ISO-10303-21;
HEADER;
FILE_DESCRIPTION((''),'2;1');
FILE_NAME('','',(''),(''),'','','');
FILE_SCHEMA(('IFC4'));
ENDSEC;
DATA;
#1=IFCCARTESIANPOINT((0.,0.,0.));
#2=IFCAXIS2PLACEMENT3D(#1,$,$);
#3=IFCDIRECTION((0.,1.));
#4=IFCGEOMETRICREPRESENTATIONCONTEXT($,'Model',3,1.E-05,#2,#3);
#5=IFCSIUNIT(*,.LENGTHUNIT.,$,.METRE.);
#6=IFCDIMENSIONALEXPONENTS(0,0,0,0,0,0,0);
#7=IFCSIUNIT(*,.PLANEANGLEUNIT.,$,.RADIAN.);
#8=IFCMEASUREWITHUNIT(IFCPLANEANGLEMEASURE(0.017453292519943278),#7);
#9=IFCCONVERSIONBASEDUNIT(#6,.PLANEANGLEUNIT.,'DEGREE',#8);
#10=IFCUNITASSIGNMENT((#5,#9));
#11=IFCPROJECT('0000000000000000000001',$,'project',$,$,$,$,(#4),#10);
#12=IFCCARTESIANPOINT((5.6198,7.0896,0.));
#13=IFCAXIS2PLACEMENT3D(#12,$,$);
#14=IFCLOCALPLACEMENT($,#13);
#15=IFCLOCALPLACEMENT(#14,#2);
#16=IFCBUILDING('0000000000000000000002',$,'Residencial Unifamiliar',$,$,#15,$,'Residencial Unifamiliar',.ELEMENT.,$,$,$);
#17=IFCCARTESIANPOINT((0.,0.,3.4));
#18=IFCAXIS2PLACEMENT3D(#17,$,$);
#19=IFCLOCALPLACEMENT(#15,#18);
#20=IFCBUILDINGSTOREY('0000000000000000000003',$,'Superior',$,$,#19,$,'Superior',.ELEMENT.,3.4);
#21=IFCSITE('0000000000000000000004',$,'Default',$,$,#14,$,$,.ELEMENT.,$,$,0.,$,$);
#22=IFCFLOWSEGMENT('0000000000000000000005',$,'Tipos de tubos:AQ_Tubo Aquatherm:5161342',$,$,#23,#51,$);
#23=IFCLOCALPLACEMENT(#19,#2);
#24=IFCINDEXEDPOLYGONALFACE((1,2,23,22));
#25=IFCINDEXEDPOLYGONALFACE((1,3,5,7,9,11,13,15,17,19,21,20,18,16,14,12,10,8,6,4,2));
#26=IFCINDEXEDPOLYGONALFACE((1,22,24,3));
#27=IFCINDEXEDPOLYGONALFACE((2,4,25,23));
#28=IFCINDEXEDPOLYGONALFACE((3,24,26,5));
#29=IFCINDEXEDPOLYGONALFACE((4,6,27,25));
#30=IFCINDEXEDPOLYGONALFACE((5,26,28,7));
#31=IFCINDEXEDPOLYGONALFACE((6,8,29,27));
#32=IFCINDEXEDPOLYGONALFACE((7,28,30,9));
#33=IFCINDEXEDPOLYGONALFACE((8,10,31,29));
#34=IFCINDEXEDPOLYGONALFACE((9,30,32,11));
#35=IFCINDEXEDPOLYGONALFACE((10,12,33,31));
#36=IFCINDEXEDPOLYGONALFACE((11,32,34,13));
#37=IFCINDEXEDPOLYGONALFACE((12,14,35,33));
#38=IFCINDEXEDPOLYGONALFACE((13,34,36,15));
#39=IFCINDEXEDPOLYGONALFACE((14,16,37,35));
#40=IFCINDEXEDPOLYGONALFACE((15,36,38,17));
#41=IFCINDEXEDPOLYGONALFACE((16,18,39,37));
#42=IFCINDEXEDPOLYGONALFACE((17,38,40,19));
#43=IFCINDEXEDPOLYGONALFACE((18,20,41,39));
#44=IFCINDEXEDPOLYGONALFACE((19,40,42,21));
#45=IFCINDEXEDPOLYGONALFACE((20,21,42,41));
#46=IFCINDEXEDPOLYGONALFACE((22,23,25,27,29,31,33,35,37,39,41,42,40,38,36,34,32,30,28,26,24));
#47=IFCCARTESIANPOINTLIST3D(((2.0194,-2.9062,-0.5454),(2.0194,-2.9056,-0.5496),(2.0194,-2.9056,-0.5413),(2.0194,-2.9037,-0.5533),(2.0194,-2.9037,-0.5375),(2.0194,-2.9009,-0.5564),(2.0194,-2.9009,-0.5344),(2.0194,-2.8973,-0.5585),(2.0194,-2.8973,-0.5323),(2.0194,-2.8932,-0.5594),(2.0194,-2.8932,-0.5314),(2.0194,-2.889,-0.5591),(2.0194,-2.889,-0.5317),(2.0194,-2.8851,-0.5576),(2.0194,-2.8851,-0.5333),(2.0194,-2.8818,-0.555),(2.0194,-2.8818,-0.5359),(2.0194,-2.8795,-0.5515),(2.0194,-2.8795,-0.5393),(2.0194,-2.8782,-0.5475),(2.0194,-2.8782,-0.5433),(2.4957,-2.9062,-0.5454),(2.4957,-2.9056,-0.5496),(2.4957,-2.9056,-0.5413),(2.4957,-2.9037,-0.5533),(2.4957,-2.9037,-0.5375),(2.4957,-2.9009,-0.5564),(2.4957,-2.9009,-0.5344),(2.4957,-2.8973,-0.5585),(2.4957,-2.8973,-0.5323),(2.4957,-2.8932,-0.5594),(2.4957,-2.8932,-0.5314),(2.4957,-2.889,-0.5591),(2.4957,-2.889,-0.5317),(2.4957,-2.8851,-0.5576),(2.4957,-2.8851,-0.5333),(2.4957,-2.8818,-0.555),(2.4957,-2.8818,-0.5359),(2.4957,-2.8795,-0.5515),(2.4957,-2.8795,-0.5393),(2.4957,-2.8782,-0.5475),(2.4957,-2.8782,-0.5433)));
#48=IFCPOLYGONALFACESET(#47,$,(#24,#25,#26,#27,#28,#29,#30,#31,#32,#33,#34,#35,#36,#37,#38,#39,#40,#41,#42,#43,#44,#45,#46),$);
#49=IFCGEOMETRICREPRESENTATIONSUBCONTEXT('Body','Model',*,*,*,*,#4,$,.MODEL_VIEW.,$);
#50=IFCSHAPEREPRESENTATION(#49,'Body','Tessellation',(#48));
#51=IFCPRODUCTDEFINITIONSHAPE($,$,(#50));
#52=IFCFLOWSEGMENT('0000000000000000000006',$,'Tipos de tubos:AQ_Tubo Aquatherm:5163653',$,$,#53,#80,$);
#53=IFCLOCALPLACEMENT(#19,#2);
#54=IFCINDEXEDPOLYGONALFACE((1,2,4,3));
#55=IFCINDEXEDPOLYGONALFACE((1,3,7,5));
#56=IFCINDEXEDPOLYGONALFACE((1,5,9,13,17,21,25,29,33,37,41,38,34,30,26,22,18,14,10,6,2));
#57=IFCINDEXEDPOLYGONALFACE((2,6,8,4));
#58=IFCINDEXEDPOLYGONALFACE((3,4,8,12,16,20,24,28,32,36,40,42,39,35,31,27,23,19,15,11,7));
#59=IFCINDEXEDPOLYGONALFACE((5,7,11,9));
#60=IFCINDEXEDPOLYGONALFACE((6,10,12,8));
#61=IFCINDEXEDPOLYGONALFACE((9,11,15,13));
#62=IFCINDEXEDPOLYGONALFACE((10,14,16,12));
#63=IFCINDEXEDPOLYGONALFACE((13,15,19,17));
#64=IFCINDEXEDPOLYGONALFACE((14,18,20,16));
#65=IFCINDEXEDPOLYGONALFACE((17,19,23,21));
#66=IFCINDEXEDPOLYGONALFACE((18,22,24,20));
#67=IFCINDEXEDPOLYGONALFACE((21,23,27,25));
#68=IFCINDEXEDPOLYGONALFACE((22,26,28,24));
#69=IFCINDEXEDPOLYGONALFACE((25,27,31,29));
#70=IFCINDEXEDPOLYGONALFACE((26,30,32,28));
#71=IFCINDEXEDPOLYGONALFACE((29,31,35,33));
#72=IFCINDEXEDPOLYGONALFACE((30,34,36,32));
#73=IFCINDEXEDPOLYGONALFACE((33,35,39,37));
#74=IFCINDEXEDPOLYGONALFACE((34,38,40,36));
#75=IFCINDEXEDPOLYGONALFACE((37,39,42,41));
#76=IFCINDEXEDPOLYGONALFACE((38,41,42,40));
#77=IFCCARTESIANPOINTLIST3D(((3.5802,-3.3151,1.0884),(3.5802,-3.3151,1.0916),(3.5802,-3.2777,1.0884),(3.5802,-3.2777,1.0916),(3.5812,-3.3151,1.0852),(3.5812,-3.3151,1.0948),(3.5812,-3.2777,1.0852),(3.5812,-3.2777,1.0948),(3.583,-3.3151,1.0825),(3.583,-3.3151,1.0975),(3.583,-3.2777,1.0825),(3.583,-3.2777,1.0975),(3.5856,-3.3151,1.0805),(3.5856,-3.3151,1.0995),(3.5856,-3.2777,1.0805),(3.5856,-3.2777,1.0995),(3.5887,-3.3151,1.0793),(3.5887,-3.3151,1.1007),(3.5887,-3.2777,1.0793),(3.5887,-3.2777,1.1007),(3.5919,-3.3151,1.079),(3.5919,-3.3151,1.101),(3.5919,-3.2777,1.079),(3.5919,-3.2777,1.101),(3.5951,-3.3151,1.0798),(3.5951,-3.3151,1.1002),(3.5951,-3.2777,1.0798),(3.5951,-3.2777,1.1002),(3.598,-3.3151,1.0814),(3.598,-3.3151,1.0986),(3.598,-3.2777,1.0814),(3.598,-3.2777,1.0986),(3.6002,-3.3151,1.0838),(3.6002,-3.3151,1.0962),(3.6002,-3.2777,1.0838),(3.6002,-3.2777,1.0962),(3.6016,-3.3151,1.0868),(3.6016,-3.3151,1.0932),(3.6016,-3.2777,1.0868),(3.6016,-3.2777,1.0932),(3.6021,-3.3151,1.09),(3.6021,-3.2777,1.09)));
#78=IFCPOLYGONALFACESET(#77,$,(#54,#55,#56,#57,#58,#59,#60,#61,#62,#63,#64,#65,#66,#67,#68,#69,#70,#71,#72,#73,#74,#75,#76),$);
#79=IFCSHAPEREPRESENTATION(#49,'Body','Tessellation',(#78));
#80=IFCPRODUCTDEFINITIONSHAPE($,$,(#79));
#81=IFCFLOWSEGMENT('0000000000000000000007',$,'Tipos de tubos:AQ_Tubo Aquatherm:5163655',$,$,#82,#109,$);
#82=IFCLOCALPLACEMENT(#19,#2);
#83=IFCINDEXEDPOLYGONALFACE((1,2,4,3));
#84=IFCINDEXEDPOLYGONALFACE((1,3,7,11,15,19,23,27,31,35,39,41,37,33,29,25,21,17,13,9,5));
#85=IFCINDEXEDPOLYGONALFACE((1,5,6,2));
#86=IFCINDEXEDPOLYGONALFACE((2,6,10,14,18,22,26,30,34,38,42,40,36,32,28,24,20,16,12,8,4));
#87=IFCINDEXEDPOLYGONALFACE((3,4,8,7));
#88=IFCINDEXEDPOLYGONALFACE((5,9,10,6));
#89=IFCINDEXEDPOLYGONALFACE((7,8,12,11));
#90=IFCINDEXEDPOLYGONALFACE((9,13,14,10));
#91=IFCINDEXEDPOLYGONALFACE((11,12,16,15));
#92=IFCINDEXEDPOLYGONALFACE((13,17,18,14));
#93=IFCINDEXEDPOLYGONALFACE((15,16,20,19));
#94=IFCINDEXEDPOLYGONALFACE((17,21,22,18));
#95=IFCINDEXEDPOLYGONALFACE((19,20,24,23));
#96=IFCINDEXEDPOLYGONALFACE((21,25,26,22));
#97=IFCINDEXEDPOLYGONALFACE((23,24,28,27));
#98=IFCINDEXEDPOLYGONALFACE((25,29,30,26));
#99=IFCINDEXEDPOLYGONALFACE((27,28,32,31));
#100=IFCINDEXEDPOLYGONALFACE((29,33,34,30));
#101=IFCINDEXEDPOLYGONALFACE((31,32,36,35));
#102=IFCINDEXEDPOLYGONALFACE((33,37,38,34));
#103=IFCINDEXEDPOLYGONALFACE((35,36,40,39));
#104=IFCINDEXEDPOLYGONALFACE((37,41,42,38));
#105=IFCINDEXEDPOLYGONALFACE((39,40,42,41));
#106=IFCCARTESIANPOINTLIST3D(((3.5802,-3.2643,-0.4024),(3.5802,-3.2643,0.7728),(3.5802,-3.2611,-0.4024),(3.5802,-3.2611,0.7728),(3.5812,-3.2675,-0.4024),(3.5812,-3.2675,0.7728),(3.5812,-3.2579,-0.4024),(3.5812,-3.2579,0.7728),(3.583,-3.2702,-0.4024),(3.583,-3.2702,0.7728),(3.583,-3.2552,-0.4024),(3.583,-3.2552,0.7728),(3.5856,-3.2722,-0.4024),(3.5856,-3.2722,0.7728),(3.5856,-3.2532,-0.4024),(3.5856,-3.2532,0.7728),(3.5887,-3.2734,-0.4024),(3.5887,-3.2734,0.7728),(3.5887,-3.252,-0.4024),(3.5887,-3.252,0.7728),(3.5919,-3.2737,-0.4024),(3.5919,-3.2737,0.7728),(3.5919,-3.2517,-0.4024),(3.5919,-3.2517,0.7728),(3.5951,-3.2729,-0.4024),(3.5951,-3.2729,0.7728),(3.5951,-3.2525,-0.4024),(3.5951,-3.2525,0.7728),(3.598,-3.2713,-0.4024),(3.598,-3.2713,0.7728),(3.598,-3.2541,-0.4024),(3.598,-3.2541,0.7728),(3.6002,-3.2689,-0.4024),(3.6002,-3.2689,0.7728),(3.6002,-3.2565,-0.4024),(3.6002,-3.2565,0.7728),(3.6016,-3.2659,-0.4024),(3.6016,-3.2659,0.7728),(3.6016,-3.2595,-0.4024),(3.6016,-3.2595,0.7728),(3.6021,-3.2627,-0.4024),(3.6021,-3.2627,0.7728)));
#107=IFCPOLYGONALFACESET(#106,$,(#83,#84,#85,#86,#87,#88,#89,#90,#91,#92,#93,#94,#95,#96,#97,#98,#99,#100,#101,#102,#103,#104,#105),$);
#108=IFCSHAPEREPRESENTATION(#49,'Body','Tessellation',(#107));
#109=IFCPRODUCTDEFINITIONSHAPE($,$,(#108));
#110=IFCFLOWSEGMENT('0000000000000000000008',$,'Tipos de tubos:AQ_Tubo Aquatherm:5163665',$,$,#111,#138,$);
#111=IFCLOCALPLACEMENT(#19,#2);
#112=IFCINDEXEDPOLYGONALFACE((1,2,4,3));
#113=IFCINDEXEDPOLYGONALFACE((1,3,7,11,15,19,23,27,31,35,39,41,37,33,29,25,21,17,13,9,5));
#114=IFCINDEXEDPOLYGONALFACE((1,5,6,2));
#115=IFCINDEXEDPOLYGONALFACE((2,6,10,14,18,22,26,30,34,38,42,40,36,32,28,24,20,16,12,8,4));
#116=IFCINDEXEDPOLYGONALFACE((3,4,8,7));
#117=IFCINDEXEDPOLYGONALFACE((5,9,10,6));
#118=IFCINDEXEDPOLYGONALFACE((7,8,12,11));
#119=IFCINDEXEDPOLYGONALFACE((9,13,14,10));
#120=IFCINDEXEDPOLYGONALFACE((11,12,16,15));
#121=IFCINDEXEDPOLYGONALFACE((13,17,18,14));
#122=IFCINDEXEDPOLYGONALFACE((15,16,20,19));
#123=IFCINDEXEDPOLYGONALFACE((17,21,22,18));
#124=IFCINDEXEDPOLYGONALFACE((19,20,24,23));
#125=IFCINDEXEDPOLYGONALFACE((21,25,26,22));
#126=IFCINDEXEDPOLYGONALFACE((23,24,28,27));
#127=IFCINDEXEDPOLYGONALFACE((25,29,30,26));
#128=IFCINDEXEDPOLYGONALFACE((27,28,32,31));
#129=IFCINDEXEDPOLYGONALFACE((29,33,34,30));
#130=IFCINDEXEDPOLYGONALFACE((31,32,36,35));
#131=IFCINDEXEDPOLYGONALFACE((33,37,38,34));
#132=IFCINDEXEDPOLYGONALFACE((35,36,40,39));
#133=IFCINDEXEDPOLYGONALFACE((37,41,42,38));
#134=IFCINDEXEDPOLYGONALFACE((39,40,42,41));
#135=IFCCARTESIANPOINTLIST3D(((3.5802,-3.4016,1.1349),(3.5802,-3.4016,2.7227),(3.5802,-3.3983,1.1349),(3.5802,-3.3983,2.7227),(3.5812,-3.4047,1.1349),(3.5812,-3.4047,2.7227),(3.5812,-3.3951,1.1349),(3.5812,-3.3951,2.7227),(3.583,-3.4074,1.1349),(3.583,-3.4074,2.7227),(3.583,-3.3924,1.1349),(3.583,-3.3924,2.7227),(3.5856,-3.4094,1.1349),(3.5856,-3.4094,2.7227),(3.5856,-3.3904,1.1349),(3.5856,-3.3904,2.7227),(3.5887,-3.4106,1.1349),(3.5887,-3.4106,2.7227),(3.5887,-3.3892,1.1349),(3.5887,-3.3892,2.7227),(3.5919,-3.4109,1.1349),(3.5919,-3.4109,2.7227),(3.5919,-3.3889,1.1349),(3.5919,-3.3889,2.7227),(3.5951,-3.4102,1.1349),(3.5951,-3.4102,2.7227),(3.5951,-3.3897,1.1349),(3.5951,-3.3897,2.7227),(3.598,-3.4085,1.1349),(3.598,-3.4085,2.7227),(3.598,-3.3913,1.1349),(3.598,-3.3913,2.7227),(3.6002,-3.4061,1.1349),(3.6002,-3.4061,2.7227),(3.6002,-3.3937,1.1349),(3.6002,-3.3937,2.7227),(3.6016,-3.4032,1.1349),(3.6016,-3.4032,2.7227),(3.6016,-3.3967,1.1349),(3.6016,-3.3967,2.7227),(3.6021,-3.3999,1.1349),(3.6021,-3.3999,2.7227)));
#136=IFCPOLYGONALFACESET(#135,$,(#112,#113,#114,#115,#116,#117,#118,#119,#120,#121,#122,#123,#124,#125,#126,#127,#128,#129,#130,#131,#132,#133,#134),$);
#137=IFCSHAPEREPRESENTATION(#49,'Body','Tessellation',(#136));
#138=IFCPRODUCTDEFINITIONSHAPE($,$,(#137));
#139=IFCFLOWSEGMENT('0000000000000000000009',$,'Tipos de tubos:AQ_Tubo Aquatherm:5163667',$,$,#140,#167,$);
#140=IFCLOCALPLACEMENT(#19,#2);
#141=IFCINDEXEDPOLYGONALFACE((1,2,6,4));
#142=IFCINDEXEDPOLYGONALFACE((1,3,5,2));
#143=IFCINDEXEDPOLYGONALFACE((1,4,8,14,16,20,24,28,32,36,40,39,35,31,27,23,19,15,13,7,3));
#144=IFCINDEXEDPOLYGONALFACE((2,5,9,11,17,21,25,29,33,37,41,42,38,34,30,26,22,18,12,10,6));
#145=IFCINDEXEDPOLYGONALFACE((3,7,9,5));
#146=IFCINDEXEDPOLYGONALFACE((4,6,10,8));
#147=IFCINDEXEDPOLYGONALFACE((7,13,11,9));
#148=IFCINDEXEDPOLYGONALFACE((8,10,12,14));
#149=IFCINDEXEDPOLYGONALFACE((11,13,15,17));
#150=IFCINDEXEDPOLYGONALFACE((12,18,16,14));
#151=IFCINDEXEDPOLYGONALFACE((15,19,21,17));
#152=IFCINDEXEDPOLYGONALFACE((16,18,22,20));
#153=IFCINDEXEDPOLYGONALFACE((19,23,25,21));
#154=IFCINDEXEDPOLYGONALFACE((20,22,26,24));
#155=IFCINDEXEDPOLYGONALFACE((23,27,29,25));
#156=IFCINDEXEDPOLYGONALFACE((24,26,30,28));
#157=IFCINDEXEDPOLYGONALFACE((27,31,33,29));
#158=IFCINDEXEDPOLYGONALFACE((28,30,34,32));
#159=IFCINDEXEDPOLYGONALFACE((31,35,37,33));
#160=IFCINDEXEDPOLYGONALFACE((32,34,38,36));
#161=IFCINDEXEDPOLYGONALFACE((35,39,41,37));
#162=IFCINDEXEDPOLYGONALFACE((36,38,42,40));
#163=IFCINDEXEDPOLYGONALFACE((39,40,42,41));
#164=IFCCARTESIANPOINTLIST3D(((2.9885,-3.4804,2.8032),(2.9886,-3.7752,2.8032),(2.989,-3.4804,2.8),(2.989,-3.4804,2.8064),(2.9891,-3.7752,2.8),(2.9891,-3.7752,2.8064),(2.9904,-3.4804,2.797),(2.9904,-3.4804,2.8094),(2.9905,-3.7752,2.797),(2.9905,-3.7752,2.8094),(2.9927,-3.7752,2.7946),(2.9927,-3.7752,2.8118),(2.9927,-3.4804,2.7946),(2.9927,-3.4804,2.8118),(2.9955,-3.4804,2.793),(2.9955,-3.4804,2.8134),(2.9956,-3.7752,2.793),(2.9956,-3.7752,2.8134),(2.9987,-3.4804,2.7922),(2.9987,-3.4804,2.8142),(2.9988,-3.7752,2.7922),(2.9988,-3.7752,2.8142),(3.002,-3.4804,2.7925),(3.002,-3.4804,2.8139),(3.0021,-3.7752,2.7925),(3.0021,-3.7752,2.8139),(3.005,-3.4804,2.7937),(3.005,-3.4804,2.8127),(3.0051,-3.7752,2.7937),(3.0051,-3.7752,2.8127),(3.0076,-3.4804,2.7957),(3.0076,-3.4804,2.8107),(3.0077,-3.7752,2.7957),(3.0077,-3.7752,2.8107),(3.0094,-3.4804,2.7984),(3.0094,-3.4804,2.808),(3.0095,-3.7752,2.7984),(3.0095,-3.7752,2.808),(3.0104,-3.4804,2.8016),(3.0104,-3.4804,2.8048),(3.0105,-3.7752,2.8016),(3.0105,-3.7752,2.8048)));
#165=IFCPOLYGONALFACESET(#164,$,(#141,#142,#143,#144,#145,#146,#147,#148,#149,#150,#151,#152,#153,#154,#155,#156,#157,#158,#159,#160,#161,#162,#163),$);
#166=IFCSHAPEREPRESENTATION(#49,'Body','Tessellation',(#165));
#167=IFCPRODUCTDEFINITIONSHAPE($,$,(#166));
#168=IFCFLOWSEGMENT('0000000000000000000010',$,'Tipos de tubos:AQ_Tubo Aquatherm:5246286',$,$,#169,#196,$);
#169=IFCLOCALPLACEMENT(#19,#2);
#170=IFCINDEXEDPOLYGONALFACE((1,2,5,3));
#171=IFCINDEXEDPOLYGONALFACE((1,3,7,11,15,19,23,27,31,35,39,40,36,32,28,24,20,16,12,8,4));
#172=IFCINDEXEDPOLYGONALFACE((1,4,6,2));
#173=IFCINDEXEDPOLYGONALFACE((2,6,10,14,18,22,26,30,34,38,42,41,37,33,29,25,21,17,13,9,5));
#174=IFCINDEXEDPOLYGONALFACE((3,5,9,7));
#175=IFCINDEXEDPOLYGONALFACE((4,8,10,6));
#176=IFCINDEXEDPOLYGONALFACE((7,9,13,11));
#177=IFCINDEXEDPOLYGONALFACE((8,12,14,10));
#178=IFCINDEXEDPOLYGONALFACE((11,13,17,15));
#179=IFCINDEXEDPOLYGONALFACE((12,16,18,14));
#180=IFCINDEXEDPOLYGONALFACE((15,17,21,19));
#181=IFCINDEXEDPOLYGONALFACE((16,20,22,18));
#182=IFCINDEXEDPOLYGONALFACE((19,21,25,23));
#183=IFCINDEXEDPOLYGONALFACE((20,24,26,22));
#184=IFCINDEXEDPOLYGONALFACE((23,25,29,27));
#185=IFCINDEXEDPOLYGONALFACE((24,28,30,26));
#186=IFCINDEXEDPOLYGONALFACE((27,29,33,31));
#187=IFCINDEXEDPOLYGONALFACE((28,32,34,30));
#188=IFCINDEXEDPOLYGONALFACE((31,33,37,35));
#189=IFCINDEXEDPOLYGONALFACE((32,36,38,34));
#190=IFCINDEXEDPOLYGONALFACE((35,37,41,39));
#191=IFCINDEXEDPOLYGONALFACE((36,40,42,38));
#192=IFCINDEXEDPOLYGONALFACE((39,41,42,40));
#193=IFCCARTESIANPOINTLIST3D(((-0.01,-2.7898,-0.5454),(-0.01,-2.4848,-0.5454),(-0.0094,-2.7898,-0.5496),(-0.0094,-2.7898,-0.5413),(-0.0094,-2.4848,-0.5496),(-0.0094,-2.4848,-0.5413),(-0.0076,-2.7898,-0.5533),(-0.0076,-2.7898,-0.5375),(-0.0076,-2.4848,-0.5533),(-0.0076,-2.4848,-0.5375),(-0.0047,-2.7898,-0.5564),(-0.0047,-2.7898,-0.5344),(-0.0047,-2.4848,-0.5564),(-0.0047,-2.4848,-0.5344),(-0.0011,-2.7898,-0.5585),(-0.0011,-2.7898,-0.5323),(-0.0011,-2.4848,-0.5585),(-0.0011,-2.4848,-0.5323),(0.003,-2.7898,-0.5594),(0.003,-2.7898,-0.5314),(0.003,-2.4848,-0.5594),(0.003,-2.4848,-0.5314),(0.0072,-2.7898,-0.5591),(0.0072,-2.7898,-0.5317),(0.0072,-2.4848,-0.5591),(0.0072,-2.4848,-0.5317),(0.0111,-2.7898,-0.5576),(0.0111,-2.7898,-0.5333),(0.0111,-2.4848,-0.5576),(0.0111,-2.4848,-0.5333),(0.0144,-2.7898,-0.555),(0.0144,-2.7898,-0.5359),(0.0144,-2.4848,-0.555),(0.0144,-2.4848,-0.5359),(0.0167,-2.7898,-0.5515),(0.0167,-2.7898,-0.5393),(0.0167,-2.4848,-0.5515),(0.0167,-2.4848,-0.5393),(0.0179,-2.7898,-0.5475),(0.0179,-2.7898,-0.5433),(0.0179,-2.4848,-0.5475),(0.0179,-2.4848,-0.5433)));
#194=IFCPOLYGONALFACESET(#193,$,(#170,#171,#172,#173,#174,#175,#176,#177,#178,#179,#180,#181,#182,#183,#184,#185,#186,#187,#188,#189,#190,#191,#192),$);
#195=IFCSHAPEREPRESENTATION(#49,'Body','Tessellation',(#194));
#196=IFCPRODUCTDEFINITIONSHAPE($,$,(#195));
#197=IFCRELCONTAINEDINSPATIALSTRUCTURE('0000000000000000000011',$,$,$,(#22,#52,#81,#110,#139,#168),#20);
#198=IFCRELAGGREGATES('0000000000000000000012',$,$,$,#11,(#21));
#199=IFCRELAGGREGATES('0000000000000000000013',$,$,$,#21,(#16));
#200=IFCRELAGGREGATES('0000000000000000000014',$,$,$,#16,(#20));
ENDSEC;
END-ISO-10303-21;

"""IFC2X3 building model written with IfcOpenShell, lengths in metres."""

from ifc_helpers import new_model, entity, si_unit, converted_unit, direction, frame, frame_2d, origin, origin_2d_with_axis, place, context, subcontext, project, spatial, circle, extrude, element, save


model = new_model("IFC2X3")

# Units and contexts
model_context = context("Model", 3, precision=1e-05, world=origin(), true_north=direction((0.0, 1.0)))
body_context = subcontext(model_context, "Body", "Model", "MODEL_VIEW")
ifc_project = project(units=[si_unit("LENGTHUNIT", "METRE"), converted_unit("PLANEANGLEUNIT", "DEGREE", entity("IfcPlaneAngleMeasure", 0.017453292519943278), si_unit("PLANEANGLEUNIT", "RADIAN"), dimensions=[0, 0, 0, 0, 0, 0, 0])], contexts=[model_context])

# Site, building, storey
site_placement = place(None, frame((5.6198, 7.0896, 0.0)))
site = spatial("IfcSite", under=ifc_project, at=site_placement, Name="Default", CompositionType="ELEMENT", RefElevation=0.0)
building_placement = place(site_placement, origin())
building = spatial("IfcBuilding", under=site, at=building_placement, Name="Residencial Unifamiliar", LongName="Residencial Unifamiliar", CompositionType="ELEMENT")
storey_placement = place(building_placement, frame((0.0, 0.0, 3.4)))
storey = spatial("IfcBuildingStorey", under=building, at=storey_placement, Name="Superior", LongName="Superior", CompositionType="ELEMENT", Elevation=3.4)

# Flow segments
flow_segment_1_placement = place(storey_placement, origin())
element("IfcFlowSegment", 1, at=flow_segment_1_placement, inside=storey, Name="Tipos de tubos:AQ_Tubo Aquatherm:5161342", context=body_context, shape_type="SweptSolid", body=[
    extrude(circle(Radius=0.0141, at=origin_2d_with_axis()), frame((2.0194, -2.8921, -0.5454), z_axis=(1.0, 0.0, 0.0), x_axis=(0.0, -1.0, 0.0)), (0.0, 0.0, 1.0), 0.4763),
])
flow_segment_2_placement = place(storey_placement, origin())
element("IfcFlowSegment", 2, at=flow_segment_2_placement, inside=storey, Name="Tipos de tubos:AQ_Tubo Aquatherm:5163653", context=body_context, shape_type="SweptSolid", body=[
    extrude(circle(Radius=0.011, at=origin_2d_with_axis()), frame((3.5911, -3.3151, 1.09), z_axis=(0.0, 1.0, 0.0), x_axis=(1.0, 0.0, 0.0)), (0.0, 0.0, 1.0), 0.0374),
])
flow_segment_3_placement = place(storey_placement, origin())
element("IfcFlowSegment", 3, at=flow_segment_3_placement, inside=storey, Name="Tipos de tubos:AQ_Tubo Aquatherm:5163655", context=body_context, shape_type="SweptSolid", body=[
    extrude(circle(Radius=0.011, at=origin_2d_with_axis()), frame((3.5911, -3.2627, -0.4024)), (0.0, 0.0, 1.0), 1.1752),
])
flow_segment_4_placement = place(storey_placement, origin())
element("IfcFlowSegment", 4, at=flow_segment_4_placement, inside=storey, Name="Tipos de tubos:AQ_Tubo Aquatherm:5163665", context=body_context, shape_type="SweptSolid", body=[
    extrude(circle(Radius=0.011, at=frame_2d((0.0, 0.0), x_axis=(1.0, 0.0))), frame((3.5911, -3.3999, 1.1349)), (0.0, 0.0, 1.0), 1.5878),
])
flow_segment_5_placement = place(storey_placement, origin())
element("IfcFlowSegment", 5, at=flow_segment_5_placement, inside=storey, Name="Tipos de tubos:AQ_Tubo Aquatherm:5163667", context=body_context, shape_type="SweptSolid", body=[
    extrude(circle(Radius=0.011, at=origin_2d_with_axis()), frame((2.9995, -3.4804, 2.8032), z_axis=(0.000245, -1.0, 0.0), x_axis=(-1.0, -0.000245, 0.0)), (0.0, 0.0, 1.0), 0.2948),
])
flow_segment_6_placement = place(storey_placement, origin())
element("IfcFlowSegment", 6, at=flow_segment_6_placement, inside=storey, Name="Tipos de tubos:AQ_Tubo Aquatherm:5246286", context=body_context, shape_type="SweptSolid", body=[
    extrude(circle(Radius=0.0141, at=frame_2d((0.0, 0.0), x_axis=(1.0, 0.0))), frame((0.0041, -2.7898, -0.5454), z_axis=(-0.000006, 1.0, 0.0), x_axis=(-1.0, -0.000006, 0.0)), (0.0, 0.0, 1.0), 0.305),
])

save(model, "model.ifc")
